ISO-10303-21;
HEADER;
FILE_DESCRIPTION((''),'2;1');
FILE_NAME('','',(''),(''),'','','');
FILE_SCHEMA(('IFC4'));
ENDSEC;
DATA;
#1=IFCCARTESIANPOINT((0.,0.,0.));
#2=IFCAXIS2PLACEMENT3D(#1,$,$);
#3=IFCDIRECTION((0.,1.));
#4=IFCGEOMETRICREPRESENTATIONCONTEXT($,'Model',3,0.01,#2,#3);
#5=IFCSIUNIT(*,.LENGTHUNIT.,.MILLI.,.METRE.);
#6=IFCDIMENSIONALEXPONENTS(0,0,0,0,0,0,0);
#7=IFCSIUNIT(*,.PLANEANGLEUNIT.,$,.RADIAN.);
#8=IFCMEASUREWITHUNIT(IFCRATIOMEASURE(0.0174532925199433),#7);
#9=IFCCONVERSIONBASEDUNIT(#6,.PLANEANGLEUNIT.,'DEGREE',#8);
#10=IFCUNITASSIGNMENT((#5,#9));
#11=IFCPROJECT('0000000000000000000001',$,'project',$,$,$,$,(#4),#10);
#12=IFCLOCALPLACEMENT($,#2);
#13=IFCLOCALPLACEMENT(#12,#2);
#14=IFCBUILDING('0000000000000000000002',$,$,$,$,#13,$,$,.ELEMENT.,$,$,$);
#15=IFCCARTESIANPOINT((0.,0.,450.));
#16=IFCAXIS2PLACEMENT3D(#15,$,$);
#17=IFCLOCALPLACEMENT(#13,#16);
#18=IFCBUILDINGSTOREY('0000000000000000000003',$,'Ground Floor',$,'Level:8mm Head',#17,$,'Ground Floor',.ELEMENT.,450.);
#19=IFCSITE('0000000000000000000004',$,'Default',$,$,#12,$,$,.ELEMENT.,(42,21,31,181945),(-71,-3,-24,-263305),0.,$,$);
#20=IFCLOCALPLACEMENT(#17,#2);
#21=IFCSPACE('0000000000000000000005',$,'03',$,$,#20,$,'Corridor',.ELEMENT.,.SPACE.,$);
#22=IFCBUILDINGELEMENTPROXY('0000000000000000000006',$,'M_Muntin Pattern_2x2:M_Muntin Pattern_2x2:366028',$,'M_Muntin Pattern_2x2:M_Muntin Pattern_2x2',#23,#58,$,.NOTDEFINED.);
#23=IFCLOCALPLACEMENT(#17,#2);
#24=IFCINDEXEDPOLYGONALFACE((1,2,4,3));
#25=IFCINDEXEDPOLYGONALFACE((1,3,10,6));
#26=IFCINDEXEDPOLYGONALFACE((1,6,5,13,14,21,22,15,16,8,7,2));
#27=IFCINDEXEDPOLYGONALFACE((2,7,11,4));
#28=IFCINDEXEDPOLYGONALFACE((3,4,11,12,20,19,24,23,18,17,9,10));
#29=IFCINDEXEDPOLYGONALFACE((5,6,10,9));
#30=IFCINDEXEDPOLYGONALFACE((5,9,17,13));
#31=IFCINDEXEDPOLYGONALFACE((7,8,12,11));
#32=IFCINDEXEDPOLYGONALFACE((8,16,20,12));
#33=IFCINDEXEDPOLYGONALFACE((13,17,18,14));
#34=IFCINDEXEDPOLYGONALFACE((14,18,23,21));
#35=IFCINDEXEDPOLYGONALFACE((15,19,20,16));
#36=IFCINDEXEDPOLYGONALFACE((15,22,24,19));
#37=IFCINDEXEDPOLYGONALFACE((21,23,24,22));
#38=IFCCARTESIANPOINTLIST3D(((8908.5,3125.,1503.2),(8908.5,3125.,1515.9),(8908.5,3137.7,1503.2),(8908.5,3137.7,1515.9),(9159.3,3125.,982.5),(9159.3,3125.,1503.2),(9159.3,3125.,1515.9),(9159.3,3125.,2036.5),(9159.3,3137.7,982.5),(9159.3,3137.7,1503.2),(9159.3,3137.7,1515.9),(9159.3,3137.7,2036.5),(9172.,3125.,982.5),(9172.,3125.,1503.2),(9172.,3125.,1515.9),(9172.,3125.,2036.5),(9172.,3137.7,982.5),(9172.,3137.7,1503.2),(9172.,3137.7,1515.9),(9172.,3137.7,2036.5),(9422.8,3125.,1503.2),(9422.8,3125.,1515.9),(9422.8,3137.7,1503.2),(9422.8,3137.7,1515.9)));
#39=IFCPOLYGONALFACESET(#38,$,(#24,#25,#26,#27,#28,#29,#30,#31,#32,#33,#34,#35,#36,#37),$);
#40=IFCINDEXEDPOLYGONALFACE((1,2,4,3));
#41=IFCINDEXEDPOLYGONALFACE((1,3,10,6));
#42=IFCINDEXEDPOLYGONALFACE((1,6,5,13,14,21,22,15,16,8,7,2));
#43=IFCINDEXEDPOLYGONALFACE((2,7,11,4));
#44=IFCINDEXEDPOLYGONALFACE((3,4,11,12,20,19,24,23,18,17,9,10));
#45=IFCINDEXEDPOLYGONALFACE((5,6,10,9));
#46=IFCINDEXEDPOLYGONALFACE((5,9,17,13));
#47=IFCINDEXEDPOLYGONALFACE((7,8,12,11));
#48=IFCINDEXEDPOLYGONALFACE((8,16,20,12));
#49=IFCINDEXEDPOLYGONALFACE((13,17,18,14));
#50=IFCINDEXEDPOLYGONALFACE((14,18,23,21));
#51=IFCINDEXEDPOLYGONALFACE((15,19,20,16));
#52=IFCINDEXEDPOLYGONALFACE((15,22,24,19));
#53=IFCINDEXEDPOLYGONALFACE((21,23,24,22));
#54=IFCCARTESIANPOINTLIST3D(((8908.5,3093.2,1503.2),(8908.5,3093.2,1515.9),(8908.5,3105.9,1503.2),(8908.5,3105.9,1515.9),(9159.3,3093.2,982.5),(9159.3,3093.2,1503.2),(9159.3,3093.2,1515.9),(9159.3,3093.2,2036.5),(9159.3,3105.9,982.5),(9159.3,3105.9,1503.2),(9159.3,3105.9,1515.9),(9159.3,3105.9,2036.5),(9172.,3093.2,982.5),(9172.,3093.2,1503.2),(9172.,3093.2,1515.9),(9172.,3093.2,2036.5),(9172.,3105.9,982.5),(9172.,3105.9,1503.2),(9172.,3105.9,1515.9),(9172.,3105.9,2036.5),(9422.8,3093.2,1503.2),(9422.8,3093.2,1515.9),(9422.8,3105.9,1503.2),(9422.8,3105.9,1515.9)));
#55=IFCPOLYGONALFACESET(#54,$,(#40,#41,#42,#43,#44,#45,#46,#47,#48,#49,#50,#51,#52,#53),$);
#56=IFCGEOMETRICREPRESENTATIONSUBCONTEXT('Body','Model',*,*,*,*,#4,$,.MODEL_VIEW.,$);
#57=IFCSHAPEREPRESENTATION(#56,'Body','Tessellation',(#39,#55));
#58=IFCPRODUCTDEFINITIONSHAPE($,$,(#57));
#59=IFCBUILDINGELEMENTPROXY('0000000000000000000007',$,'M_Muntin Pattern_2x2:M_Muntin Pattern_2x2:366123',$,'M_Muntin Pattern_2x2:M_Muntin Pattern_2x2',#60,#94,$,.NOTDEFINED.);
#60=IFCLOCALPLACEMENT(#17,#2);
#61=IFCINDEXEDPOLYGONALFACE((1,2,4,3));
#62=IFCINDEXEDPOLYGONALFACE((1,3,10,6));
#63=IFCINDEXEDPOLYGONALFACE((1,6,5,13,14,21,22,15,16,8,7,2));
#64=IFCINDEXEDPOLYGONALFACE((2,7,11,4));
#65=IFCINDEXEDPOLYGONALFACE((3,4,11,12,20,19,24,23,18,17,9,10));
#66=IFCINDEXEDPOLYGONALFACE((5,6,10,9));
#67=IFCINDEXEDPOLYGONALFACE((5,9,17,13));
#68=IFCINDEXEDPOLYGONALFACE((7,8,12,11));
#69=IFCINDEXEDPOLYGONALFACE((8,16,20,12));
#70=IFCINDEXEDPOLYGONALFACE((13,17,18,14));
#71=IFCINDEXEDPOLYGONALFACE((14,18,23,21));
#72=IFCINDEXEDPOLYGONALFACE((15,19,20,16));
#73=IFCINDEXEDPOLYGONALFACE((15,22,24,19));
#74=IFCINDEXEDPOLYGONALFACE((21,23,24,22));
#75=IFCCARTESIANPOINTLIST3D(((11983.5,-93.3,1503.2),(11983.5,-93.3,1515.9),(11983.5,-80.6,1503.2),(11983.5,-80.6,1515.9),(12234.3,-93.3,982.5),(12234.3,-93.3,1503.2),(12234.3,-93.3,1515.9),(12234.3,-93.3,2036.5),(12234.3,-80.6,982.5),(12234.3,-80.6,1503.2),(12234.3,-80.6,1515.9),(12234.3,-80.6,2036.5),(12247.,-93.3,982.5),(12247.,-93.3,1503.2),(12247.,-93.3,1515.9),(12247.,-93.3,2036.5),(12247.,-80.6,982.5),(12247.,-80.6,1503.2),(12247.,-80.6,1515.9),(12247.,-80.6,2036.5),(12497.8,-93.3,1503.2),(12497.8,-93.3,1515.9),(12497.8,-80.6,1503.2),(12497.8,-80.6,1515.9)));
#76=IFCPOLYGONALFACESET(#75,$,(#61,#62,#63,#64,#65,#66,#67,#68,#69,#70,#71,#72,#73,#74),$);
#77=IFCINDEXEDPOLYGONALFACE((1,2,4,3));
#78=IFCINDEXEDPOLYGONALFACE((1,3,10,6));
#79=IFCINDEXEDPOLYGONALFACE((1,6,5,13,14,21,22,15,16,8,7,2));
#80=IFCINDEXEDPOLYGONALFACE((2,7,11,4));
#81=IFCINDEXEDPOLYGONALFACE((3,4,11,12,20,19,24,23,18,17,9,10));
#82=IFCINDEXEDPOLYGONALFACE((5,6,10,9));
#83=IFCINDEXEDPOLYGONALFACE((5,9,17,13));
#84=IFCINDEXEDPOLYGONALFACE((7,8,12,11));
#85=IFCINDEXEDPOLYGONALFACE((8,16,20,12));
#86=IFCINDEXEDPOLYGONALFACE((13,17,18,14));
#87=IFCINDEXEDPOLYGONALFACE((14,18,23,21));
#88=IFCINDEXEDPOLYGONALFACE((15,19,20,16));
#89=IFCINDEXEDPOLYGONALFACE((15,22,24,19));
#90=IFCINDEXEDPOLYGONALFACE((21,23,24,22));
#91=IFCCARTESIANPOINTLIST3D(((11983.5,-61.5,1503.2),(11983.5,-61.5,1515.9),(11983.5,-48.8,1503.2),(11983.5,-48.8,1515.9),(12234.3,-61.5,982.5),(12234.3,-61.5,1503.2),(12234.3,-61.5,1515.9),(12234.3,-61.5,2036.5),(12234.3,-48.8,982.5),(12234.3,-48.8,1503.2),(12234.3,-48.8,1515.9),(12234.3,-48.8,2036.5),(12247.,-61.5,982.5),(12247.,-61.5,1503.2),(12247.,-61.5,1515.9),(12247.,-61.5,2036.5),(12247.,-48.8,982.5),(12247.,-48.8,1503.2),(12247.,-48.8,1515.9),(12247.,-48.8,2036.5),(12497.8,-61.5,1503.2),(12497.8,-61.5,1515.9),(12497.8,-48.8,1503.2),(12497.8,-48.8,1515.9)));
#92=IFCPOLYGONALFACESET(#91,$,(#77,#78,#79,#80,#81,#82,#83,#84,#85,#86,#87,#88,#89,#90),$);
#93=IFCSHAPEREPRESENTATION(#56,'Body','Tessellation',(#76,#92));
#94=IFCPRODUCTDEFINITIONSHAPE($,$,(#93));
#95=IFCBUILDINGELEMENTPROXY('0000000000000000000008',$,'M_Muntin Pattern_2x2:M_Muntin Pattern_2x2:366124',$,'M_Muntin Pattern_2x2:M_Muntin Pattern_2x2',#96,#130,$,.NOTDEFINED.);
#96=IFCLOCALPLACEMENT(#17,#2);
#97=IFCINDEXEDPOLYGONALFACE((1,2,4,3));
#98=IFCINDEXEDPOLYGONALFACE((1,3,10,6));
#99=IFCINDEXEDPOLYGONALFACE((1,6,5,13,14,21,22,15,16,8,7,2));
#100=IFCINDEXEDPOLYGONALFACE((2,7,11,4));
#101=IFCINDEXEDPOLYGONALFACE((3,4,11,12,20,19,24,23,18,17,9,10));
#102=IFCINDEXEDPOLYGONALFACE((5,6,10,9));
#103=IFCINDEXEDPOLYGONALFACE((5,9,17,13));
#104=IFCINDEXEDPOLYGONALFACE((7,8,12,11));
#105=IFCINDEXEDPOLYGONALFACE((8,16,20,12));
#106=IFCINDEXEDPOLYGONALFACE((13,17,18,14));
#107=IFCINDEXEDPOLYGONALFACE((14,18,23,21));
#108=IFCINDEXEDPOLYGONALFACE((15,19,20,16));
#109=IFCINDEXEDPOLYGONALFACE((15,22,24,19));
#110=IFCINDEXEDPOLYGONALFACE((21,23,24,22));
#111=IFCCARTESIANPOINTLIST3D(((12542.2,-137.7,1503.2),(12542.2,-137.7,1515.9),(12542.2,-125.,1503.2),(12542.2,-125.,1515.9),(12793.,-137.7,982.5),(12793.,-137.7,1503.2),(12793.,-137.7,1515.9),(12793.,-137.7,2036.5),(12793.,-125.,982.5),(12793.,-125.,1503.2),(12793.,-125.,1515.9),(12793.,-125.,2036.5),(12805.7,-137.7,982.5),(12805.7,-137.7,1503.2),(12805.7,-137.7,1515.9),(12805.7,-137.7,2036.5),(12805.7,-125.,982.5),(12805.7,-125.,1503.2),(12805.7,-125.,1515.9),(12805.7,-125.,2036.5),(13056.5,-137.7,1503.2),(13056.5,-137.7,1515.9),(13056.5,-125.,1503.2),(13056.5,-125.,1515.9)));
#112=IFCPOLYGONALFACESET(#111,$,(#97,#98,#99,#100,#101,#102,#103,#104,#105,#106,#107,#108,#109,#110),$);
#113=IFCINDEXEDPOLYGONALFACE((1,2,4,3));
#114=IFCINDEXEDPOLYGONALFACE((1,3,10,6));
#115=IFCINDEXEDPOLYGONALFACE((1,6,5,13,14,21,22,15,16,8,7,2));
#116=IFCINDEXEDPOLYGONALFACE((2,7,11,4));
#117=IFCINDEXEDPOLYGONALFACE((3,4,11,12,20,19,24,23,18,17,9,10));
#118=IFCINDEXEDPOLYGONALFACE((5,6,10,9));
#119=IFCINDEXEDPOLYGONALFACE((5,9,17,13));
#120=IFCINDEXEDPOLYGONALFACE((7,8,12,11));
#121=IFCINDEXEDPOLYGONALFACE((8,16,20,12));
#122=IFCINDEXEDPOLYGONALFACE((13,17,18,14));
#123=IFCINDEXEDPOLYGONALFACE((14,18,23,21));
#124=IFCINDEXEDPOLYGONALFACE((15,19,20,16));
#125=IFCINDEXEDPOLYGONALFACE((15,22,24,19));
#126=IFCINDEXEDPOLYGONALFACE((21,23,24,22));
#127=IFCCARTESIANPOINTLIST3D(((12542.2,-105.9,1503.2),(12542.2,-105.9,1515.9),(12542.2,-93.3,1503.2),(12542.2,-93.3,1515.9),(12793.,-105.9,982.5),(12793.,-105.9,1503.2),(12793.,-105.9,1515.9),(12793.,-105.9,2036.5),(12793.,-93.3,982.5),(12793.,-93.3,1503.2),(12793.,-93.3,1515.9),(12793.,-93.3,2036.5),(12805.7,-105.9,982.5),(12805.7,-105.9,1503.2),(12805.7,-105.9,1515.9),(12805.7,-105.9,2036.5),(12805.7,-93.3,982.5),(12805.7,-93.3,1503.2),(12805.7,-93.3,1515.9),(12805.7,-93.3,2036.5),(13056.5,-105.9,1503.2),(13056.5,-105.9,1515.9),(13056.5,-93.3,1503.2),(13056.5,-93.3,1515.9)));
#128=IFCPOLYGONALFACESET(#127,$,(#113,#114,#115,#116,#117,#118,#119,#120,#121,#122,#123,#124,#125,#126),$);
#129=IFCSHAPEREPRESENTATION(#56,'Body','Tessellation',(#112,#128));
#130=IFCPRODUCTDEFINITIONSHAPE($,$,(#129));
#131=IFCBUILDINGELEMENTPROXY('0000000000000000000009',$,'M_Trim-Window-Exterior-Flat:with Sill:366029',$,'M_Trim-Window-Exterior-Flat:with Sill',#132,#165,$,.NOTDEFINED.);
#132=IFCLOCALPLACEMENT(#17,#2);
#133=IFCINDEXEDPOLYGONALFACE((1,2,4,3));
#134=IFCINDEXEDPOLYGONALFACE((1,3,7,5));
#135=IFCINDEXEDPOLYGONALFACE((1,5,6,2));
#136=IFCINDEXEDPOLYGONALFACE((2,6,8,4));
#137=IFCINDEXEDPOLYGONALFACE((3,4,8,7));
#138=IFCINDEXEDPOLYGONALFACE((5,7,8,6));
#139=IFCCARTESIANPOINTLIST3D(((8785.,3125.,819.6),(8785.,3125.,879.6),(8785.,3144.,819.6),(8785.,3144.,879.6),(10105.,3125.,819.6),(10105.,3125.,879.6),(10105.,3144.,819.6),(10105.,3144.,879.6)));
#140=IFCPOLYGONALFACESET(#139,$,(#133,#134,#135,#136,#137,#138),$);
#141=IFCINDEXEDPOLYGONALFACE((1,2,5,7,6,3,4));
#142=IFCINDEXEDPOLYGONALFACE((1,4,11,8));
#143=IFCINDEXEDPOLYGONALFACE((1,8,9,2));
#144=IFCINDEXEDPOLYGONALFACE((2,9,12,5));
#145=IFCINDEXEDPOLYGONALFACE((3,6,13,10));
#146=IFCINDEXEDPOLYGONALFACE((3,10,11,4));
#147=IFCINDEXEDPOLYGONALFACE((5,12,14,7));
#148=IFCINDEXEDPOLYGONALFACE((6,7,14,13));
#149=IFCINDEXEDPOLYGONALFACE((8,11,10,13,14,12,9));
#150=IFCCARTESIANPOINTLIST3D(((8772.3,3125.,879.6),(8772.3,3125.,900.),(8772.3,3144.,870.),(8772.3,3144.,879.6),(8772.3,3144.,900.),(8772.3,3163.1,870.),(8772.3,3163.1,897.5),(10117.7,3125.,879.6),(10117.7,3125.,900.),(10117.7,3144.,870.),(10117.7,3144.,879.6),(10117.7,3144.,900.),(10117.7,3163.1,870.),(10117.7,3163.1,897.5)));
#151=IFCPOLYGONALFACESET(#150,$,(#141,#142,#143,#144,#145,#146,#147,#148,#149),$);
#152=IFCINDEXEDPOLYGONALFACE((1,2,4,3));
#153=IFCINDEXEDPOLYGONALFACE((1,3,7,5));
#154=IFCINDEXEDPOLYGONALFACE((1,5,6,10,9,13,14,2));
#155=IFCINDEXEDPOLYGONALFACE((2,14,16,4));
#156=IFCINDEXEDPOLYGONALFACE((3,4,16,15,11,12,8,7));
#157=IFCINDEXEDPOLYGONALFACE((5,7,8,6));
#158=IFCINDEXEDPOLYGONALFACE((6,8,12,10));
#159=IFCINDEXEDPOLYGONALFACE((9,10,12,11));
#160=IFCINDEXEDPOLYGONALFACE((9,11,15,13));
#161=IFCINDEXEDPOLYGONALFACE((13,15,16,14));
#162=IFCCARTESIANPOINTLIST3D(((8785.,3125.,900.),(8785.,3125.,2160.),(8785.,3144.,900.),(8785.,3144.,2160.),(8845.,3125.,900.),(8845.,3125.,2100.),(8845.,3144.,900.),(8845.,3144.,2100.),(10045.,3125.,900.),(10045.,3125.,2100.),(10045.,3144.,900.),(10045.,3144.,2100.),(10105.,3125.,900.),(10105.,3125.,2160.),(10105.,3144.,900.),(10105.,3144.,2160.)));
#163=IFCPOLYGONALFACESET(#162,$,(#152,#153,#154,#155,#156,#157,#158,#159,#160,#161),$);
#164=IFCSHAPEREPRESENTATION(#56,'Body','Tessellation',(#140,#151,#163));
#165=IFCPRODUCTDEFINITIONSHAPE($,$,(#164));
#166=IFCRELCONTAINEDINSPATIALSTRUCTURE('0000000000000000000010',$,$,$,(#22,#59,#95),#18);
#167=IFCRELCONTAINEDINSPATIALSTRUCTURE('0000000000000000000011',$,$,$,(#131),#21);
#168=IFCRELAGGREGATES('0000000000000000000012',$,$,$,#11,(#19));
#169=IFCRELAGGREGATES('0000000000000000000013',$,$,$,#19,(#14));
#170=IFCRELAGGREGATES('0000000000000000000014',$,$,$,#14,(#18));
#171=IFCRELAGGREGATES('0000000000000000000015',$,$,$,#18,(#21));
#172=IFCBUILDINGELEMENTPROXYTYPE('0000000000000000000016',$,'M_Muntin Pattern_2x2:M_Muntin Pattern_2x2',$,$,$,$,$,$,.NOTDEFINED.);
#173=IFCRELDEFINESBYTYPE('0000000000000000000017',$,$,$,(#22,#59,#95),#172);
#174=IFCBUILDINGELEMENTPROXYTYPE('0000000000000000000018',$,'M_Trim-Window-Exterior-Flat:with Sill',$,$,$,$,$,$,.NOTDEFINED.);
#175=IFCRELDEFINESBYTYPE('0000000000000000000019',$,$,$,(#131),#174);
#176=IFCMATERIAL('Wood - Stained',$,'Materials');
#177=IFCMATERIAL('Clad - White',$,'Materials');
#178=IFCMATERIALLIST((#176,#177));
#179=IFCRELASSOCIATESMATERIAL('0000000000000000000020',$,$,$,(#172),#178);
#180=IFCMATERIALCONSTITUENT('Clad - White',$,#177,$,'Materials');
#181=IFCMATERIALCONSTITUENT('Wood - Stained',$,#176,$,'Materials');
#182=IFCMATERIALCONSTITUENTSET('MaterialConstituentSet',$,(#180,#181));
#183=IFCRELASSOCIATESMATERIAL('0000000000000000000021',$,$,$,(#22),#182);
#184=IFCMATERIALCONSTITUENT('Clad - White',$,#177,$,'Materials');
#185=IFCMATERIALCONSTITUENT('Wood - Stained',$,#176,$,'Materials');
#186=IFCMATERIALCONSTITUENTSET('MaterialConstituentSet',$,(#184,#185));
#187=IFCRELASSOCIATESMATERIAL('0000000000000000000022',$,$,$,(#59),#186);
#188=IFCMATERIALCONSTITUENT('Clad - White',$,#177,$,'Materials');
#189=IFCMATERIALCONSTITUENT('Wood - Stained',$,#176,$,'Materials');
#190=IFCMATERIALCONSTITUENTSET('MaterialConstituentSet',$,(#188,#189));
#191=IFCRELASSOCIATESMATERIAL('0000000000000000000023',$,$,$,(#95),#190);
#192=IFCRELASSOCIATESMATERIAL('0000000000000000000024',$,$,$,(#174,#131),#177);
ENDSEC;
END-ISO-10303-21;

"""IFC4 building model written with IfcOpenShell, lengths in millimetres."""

from ifc_helpers import new_model, entity, si_unit, converted_unit, direction, frame, frame_2d, origin, place, context, subcontext, project, spatial, polyline, rectangle, outline, extrude, source, transform, mapped, material, material_list, constituent, constituent_set, type_object, type_shapes, element, save


model = new_model("IFC4")

# Units and contexts
model_context = context("Model", 3, precision=0.01, world=origin(), true_north=direction((0.0, 1.0)))
body_context = subcontext(model_context, "Body", "Model", "MODEL_VIEW")
ifc_project = project(units=[si_unit("LENGTHUNIT", "METRE", prefix="MILLI"), converted_unit("PLANEANGLEUNIT", "DEGREE", entity("IfcRatioMeasure", 0.0174532925199433), si_unit("PLANEANGLEUNIT", "RADIAN"), dimensions=[0, 0, 0, 0, 0, 0, 0])], contexts=[model_context])

# Site, building, storey
site_placement = place(None, origin())
site = spatial("IfcSite", under=ifc_project, at=site_placement, Name="Default", CompositionType="ELEMENT", RefLatitude=(42, 21, 31, 181945), RefLongitude=(-71, -3, -24, -263305), RefElevation=0.0)
building_placement = place(site_placement, origin())
building = spatial("IfcBuilding", under=site, at=building_placement, CompositionType="ELEMENT")
storey_placement = place(building_placement, frame((0.0, 0.0, 450.0)))
storey = spatial("IfcBuildingStorey", under=building, at=storey_placement, Name="Ground Floor", ObjectType="Level:8mm Head", LongName="Ground Floor", CompositionType="ELEMENT", Elevation=450.0)

# Building element proxies
ifc_material_1 = material(Name="Clad - White", Category="Materials")
ifc_material_2 = material(Name="Wood - Stained", Category="Materials")
ifc_material_list_1 = material_list([ifc_material_2, ifc_material_1])
building_element_proxy_type_1 = type_object("IfcBuildingElementProxyType", Name="M_Muntin Pattern_2x2:M_Muntin Pattern_2x2", PredefinedType="NOTDEFINED", material=ifc_material_list_1)
shared_shape_1 = source(origin(), body_context, "Body", "SweptSolid", [
    extrude(outline(polyline([(6.4, -6.4), (527.0, -6.4), (527.0, 6.3), (6.4, 6.3), (6.4, 257.1), (-6.3, 257.1), (-6.3, 6.3), (-527.0, 6.3), (-527.0, -6.4), (-6.3, -6.4), (-6.3, -257.1), (6.4, -257.1), (6.4, -6.4)])), frame((0.0, 9.5, 527.0), z_axis=(0.0, 1.0, 0.0), x_axis=(0.0, 0.0, 1.0)), (0.0, 0.0, 1.0), 12.7),
    extrude(outline(polyline([(6.4, -6.4), (527.0, -6.4), (527.0, 6.3), (6.4, 6.3), (6.4, 257.1), (-6.3, 257.1), (-6.3, 6.3), (-527.0, 6.3), (-527.0, -6.4), (-6.3, -6.4), (-6.3, -257.1), (6.4, -257.1), (6.4, -6.4)])), frame((0.0, -22.2, 527.0), z_axis=(0.0, 1.0, 0.0), x_axis=(0.0, 0.0, 1.0)), (0.0, 0.0, 1.0), 12.7),
])
type_shapes(building_element_proxy_type_1, [shared_shape_1])
ifc_constituent_1 = constituent(ifc_material_1, Name="Clad - White", Category="Materials")
ifc_constituent_2 = constituent(ifc_material_2, Name="Wood - Stained", Category="Materials")
ifc_constituent_set_1 = constituent_set(constituents=[ifc_constituent_1, ifc_constituent_2], Name="MaterialConstituentSet")
proxy_1_placement = place(storey_placement, frame((9165.6, 3115.5, 982.5)))
element("IfcBuildingElementProxy", 1, at=proxy_1_placement, inside=storey, type_object=building_element_proxy_type_1, material=ifc_constituent_set_1, Name="M_Muntin Pattern_2x2:M_Muntin Pattern_2x2:366028", ObjectType="M_Muntin Pattern_2x2:M_Muntin Pattern_2x2", PredefinedType="NOTDEFINED", context=body_context, shape_type="MappedRepresentation", body=[
    mapped(shared_shape_1, transform((0.0, 0.0, 0.0), scale=1.0)),
])
ifc_constituent_3 = constituent(ifc_material_1, Name="Clad - White", Category="Materials")
ifc_constituent_4 = constituent(ifc_material_2, Name="Wood - Stained", Category="Materials")
ifc_constituent_set_2 = constituent_set(constituents=[ifc_constituent_3, ifc_constituent_4], Name="MaterialConstituentSet")
proxy_2_placement = place(storey_placement, frame((12240.6, -71.0, 982.5), z_axis=(0.0, 0.0, 1.0), x_axis=(-1.0, 0.0, 0.0)))
element("IfcBuildingElementProxy", 2, at=proxy_2_placement, inside=storey, type_object=building_element_proxy_type_1, material=ifc_constituent_set_2, Name="M_Muntin Pattern_2x2:M_Muntin Pattern_2x2:366123", ObjectType="M_Muntin Pattern_2x2:M_Muntin Pattern_2x2", PredefinedType="NOTDEFINED", context=body_context, shape_type="MappedRepresentation", body=[
    mapped(shared_shape_1, transform((0.0, 0.0, 0.0), scale=1.0)),
])
ifc_constituent_5 = constituent(ifc_material_1, Name="Clad - White", Category="Materials")
ifc_constituent_6 = constituent(ifc_material_2, Name="Wood - Stained", Category="Materials")
ifc_constituent_set_3 = constituent_set(constituents=[ifc_constituent_5, ifc_constituent_6], Name="MaterialConstituentSet")
proxy_3_placement = place(storey_placement, frame((12799.4, -115.5, 982.5), z_axis=(0.0, 0.0, 1.0), x_axis=(-1.0, 0.0, 0.0)))
element("IfcBuildingElementProxy", 3, at=proxy_3_placement, inside=storey, type_object=building_element_proxy_type_1, material=ifc_constituent_set_3, Name="M_Muntin Pattern_2x2:M_Muntin Pattern_2x2:366124", ObjectType="M_Muntin Pattern_2x2:M_Muntin Pattern_2x2", PredefinedType="NOTDEFINED", context=body_context, shape_type="MappedRepresentation", body=[
    mapped(shared_shape_1, transform((0.0, 0.0, 0.0), scale=1.0)),
])

# Shared definitions
space_1_placement = place(storey_placement, origin())
space_1 = spatial("IfcSpace", under=storey, at=space_1_placement, Name="03", LongName="Corridor", CompositionType="ELEMENT", PredefinedType="SPACE")

# Building element proxy
building_element_proxy_type_2 = type_object("IfcBuildingElementProxyType", Name="M_Trim-Window-Exterior-Flat:with Sill", PredefinedType="NOTDEFINED", material=ifc_material_1)
shared_shape_2 = source(origin(), body_context, "Body", "SweptSolid", [
    extrude(rectangle(XDim=1320.0, YDim=60.0, at=frame_2d((0.0, 0.0), x_axis=(1.0, 0.0))), frame((0.0, -1250.4, 0.0), z_axis=(0.0, 0.0, 1.0), x_axis=(-1.0, 0.0, 0.0)), (0.0, 0.0, 1.0), 19.1),
    extrude(outline(polyline([(-19.0, -15.2), (0.0, -15.2), (0.0, -5.7), (19.0, -5.7), (19.0, 14.8), (0.0, 14.8), (-19.0, 12.3), (-19.0, -15.2)])), frame((-672.7, -1214.8, 19.0), z_axis=(1.0, 0.0, 0.0), x_axis=(0.0, 0.0, -1.0)), (0.0, 0.0, 1.0), 1345.4),
    extrude(outline(polyline([(-645.0, -660.0), (615.0, -660.0), (615.0, -600.0), (-585.0, -600.0), (-585.0, 600.0), (615.0, 600.0), (615.0, 660.0), (-645.0, 660.0), (-645.0, -660.0)])), frame((0.0, -585.0, 0.0), z_axis=(0.0, 0.0, 1.0), x_axis=(0.0, -1.0, 0.0)), (0.0, 0.0, 1.0), 19.1),
])
type_shapes(building_element_proxy_type_2, [shared_shape_2])
proxy_4_placement = place(space_1_placement, frame((9445.0, 3125.0, 2100.0), z_axis=(0.0, 1.0, 0.0), x_axis=(-1.0, 0.0, 0.0)))
element("IfcBuildingElementProxy", 4, at=proxy_4_placement, inside=space_1, type_object=building_element_proxy_type_2, material=ifc_material_1, Name="M_Trim-Window-Exterior-Flat:with Sill:366029", ObjectType="M_Trim-Window-Exterior-Flat:with Sill", PredefinedType="NOTDEFINED", context=body_context, shape_type="MappedRepresentation", body=[
    mapped(shared_shape_2, transform((0.0, 0.0, 0.0), scale=1.0)),
])

save(model, "model.ifc")
